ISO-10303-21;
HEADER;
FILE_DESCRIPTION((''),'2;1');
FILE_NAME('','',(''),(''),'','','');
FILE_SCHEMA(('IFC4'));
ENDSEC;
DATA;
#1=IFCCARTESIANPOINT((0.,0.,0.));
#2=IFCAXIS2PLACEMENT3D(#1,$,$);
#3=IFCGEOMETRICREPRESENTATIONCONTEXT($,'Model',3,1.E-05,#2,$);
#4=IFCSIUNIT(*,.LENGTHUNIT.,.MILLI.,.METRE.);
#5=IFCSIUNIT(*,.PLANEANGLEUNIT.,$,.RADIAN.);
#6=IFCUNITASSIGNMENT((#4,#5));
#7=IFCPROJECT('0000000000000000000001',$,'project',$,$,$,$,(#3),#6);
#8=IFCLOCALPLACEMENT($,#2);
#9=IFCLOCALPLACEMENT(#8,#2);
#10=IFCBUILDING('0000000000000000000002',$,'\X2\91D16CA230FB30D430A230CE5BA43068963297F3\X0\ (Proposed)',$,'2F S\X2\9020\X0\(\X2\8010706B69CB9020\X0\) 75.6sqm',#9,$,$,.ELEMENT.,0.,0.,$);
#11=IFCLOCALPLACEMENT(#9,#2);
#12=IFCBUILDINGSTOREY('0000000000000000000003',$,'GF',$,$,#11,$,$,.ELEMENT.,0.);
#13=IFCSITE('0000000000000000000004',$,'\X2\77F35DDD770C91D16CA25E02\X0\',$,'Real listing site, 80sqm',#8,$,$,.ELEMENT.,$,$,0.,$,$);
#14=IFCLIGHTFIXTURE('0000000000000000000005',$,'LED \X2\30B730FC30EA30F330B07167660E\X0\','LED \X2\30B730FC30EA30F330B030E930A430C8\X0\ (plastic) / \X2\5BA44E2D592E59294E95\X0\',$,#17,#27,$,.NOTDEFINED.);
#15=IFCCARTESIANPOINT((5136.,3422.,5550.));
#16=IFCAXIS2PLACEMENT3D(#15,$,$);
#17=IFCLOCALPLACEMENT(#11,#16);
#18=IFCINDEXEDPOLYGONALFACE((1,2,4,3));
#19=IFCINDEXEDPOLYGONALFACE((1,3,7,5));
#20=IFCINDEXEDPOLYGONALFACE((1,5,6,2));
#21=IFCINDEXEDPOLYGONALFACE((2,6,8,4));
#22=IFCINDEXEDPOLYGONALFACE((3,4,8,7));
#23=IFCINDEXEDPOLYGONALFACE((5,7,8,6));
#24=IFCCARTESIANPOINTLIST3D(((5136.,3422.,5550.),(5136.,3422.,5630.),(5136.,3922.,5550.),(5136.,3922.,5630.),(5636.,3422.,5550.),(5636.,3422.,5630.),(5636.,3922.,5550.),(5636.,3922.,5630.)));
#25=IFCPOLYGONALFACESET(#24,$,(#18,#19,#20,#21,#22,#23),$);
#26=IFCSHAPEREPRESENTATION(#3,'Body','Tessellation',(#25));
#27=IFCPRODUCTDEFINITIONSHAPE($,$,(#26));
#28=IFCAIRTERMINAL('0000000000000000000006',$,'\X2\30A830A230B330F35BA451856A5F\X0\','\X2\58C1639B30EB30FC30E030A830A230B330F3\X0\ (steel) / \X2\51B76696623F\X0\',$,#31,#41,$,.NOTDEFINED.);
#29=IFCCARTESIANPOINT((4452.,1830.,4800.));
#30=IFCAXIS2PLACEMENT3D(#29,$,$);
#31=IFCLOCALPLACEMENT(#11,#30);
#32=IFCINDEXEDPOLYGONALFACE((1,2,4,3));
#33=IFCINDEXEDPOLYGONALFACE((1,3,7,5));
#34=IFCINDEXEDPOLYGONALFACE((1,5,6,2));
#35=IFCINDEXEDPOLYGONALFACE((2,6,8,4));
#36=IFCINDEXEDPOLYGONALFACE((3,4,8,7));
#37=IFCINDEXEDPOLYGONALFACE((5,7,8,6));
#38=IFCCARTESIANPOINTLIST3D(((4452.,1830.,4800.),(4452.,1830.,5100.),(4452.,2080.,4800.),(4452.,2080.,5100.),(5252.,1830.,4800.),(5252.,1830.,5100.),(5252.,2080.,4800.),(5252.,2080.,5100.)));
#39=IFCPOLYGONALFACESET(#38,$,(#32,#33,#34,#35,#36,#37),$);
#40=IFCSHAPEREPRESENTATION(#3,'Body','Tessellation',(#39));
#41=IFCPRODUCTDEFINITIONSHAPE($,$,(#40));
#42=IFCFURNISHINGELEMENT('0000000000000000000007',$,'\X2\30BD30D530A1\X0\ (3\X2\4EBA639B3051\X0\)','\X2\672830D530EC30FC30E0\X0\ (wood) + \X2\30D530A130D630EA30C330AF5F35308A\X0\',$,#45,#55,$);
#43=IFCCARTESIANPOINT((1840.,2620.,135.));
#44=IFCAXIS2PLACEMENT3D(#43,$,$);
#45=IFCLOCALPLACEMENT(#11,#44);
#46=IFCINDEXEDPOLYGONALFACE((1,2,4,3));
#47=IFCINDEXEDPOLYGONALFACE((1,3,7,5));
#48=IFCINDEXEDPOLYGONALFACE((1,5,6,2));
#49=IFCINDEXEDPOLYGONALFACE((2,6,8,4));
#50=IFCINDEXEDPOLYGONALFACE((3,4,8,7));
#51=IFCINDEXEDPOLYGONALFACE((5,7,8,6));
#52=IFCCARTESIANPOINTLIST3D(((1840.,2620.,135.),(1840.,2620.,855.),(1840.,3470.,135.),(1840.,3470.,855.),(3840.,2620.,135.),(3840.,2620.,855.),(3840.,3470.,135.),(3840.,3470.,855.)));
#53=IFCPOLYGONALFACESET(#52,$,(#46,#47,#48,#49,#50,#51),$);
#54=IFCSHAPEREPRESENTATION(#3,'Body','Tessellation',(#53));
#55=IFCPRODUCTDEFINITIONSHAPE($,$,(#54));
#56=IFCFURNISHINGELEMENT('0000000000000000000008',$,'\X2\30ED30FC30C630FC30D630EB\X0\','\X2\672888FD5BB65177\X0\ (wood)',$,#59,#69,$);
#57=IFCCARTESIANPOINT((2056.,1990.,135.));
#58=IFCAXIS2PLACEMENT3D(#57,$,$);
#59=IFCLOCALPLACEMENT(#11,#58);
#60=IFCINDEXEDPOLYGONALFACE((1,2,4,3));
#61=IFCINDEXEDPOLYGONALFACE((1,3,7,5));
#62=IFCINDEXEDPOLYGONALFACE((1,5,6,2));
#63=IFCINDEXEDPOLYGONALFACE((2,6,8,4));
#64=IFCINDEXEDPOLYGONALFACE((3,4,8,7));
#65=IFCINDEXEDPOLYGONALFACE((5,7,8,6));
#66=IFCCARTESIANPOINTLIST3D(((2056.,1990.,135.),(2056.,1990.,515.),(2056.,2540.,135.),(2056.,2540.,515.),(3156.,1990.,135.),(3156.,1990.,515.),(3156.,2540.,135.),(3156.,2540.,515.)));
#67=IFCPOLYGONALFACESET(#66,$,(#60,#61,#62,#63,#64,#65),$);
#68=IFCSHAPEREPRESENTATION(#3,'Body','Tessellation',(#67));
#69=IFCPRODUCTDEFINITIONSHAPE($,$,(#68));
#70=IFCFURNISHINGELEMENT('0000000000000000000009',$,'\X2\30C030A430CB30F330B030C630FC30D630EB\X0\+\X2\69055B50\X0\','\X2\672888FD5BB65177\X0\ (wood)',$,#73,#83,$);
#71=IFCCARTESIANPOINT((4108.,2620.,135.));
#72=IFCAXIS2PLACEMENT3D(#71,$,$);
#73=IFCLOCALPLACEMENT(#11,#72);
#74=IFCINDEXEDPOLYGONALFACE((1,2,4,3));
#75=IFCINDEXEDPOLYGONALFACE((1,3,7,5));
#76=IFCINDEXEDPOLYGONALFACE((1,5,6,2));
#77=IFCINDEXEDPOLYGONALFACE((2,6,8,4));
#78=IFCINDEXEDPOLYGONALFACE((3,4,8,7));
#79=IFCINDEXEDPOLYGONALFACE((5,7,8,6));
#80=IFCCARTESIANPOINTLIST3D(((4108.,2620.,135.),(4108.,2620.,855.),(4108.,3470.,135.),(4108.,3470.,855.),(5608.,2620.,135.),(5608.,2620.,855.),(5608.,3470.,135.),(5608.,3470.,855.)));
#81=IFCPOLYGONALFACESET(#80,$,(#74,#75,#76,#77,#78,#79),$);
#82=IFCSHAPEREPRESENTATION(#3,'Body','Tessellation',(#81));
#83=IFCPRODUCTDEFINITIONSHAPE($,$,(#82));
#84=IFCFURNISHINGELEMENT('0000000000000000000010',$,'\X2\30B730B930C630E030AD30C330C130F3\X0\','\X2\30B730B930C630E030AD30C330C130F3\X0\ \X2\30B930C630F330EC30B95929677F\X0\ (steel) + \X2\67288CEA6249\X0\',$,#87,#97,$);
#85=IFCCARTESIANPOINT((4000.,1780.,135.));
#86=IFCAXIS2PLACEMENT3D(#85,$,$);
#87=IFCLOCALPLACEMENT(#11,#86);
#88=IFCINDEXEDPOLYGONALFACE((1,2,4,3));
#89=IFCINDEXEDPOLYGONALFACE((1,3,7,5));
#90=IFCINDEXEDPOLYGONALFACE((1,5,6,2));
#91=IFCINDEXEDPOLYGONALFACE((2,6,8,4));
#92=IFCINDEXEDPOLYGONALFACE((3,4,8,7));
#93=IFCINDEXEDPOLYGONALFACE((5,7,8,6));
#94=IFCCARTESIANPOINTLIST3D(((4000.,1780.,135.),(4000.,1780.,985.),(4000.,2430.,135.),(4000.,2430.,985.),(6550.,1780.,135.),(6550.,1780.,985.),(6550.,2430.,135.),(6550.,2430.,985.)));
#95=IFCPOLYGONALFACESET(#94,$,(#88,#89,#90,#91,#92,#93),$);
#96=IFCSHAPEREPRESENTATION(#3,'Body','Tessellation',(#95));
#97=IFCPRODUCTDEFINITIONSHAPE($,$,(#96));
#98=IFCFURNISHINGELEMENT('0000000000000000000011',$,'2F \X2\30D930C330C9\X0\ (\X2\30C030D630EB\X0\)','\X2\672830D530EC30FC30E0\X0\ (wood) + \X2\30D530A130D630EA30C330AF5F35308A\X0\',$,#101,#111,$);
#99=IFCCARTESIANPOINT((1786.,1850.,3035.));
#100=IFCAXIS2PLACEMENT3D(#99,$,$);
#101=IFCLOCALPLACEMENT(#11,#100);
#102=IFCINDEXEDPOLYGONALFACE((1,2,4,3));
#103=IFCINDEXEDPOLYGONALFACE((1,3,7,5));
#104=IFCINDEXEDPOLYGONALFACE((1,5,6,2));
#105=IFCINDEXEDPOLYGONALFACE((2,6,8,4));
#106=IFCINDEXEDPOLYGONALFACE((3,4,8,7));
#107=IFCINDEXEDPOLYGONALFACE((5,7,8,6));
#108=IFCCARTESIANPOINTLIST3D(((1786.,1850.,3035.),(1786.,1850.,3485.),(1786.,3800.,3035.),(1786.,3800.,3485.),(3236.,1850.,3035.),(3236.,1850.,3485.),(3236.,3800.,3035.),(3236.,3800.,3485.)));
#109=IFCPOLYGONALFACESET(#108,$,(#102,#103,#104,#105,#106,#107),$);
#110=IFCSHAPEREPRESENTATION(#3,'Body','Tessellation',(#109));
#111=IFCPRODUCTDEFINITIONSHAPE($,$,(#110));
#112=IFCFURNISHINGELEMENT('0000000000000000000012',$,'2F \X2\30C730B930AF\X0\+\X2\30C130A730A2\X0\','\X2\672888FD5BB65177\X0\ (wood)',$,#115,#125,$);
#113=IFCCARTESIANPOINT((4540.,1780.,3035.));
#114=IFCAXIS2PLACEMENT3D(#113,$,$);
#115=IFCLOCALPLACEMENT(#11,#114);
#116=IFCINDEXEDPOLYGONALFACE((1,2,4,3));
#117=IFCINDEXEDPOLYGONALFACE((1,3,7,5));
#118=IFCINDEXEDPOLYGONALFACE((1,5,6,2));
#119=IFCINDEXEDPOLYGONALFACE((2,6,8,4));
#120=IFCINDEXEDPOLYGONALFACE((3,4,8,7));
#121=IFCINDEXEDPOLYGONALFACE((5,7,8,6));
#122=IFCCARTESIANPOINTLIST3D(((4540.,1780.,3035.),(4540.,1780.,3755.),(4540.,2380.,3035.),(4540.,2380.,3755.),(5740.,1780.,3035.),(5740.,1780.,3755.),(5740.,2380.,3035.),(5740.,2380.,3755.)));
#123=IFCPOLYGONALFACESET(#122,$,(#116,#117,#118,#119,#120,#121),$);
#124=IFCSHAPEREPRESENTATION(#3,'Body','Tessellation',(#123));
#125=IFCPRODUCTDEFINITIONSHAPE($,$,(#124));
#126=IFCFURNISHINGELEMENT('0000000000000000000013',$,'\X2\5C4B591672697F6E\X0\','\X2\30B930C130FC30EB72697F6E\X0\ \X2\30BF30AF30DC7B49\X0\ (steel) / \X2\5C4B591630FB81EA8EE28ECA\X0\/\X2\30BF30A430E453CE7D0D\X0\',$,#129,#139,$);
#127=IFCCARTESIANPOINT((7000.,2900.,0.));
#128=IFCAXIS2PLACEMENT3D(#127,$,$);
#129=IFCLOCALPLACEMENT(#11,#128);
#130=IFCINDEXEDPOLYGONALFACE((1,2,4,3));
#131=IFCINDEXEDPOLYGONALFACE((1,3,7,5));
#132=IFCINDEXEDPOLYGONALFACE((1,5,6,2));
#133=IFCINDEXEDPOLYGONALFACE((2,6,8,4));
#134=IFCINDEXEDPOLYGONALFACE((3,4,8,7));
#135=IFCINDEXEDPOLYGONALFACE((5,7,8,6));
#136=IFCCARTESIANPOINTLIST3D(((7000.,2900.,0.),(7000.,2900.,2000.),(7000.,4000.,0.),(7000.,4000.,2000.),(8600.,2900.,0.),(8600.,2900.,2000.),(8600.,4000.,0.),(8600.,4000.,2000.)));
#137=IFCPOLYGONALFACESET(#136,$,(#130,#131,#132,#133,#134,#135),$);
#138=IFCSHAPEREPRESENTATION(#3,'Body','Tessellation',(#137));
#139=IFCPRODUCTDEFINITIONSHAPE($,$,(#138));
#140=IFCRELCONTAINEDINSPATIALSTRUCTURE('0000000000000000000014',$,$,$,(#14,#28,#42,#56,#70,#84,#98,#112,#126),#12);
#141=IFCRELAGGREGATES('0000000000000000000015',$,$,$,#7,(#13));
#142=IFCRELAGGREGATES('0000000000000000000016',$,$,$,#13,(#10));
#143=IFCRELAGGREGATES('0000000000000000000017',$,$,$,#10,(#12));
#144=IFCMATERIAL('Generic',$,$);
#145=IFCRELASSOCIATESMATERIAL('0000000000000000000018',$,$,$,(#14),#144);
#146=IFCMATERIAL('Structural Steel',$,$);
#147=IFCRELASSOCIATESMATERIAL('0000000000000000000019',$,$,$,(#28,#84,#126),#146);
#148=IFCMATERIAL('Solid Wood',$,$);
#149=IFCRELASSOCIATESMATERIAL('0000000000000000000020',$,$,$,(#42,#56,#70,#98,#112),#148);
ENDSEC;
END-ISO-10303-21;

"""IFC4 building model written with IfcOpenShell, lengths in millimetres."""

from ifc_helpers import new_model, si_unit, frame, frame_2d, origin, place, context, project, spatial, rectangle, extrude, material, element, save


model = new_model("IFC4")

# Units and contexts
model_context = context("Model", 3, precision=1e-05, world=origin())
ifc_project = project(units=[si_unit("LENGTHUNIT", "METRE", prefix="MILLI"), si_unit("PLANEANGLEUNIT", "RADIAN")], contexts=[model_context])

# Site, building, storey
site_placement = place(None, origin())
site = spatial("IfcSite", under=ifc_project, at=site_placement, Name="石川県金沢市", ObjectType="Real listing site, 80sqm", CompositionType="ELEMENT", RefElevation=0.0)
building_placement = place(site_placement, origin())
building = spatial("IfcBuilding", under=site, at=building_placement, Name="金沢・ピアノ室と防音 (Proposed)", ObjectType="2F S造(耐火構造) 75.6sqm", CompositionType="ELEMENT", ElevationOfRefHeight=0.0, ElevationOfTerrain=0.0)
storey_placement = place(building_placement, origin())
storey = spatial("IfcBuildingStorey", under=building, at=storey_placement, Name="GF", CompositionType="ELEMENT", Elevation=0.0)

# Shared definitions
ifc_material_1 = material(Name="Solid Wood")

# Shared definitions
ifc_material_2 = material(Name="Generic")

# Shared definitions
ifc_material_3 = material(Name="Structural Steel")

# Light fixture
light_fixture_placement = place(storey_placement, frame((5136.0, 3422.0, 5550.0)))
element("IfcLightFixture", 1, at=light_fixture_placement, inside=storey, material=ifc_material_2, Name="LED シーリング照明", Description="LED シーリングライト (plastic) / 室中央天井", PredefinedType="NOTDEFINED", context=model_context, shape_type="SweptSolid", body=[
    extrude(rectangle(XDim=500.0, YDim=500.0, at=frame_2d((250.0, 250.0))), frame((5136.0, 3422.0, 5550.0)), (0.0, 0.0, 1.0), 80.0),
])

# Air terminal
air_terminal_1_placement = place(storey_placement, frame((4452.0, 1830.0, 4800.0)))
element("IfcAirTerminal", 2, at=air_terminal_1_placement, inside=storey, material=ifc_material_3, Name="エアコン室内機", Description="壁掛ルームエアコン (steel) / 冷暖房", PredefinedType="NOTDEFINED", context=model_context, shape_type="SweptSolid", body=[
    extrude(rectangle(XDim=800.0, YDim=250.0, at=frame_2d((400.0, 125.0))), frame((4452.0, 1830.0, 4800.0)), (0.0, 0.0, 1.0), 300.0),
])

# Furnishing elements
furnishing_1_placement = place(storey_placement, frame((1840.0, 2620.0, 135.0)))
element("IfcFurnishingElement", 3, at=furnishing_1_placement, inside=storey, material=ifc_material_1, Name="ソファ (3人掛け)", Description="木フレーム (wood) + ファブリック張り", context=model_context, shape_type="SweptSolid", body=[
    extrude(rectangle(XDim=2000.0, YDim=850.0, at=frame_2d((1000.0, 425.0))), frame((1840.0, 2620.0, 135.0)), (0.0, 0.0, 1.0), 720.0),
])
furnishing_2_placement = place(storey_placement, frame((2056.0, 1990.0, 135.0)))
element("IfcFurnishingElement", 4, at=furnishing_2_placement, inside=storey, material=ifc_material_1, Name="ローテーブル", Description="木製家具 (wood)", context=model_context, shape_type="SweptSolid", body=[
    extrude(rectangle(XDim=1100.0, YDim=550.0, at=frame_2d((550.0, 275.0))), frame((2056.0, 1990.0, 135.0)), (0.0, 0.0, 1.0), 380.0),
])
furnishing_3_placement = place(storey_placement, frame((4108.0, 2620.0, 135.0)))
element("IfcFurnishingElement", 5, at=furnishing_3_placement, inside=storey, material=ifc_material_1, Name="ダイニングテーブル+椅子", Description="木製家具 (wood)", context=model_context, shape_type="SweptSolid", body=[
    extrude(rectangle(XDim=1500.0, YDim=850.0, at=frame_2d((750.0, 425.0))), frame((4108.0, 2620.0, 135.0)), (0.0, 0.0, 1.0), 720.0),
])
furnishing_4_placement = place(storey_placement, frame((4000.0, 1780.0, 135.0)))
element("IfcFurnishingElement", 6, at=furnishing_4_placement, inside=storey, material=ifc_material_3, Name="システムキッチン", Description="システムキッチン ステンレス天板 (steel) + 木質扉", context=model_context, shape_type="SweptSolid", body=[
    extrude(rectangle(XDim=2550.0, YDim=650.0, at=frame_2d((1275.0, 325.0))), frame((4000.0, 1780.0, 135.0)), (0.0, 0.0, 1.0), 850.0),
])
furnishing_5_placement = place(storey_placement, frame((1786.0, 1850.0, 3035.0)))
element("IfcFurnishingElement", 7, at=furnishing_5_placement, inside=storey, material=ifc_material_1, Name="2F ベッド (ダブル)", Description="木フレーム (wood) + ファブリック張り", context=model_context, shape_type="SweptSolid", body=[
    extrude(rectangle(XDim=1450.0, YDim=1950.0, at=frame_2d((725.0, 975.0))), frame((1786.0, 1850.0, 3035.0)), (0.0, 0.0, 1.0), 450.0),
])
furnishing_6_placement = place(storey_placement, frame((4540.0, 1780.0, 3035.0)))
element("IfcFurnishingElement", 8, at=furnishing_6_placement, inside=storey, material=ifc_material_1, Name="2F デスク+チェア", Description="木製家具 (wood)", context=model_context, shape_type="SweptSolid", body=[
    extrude(rectangle(XDim=1200.0, YDim=600.0, at=frame_2d((600.0, 300.0))), frame((4540.0, 1780.0, 3035.0)), (0.0, 0.0, 1.0), 720.0),
])
furnishing_7_placement = place(storey_placement, frame((7000.0, 2900.0, 0.0)))
element("IfcFurnishingElement", 9, at=furnishing_7_placement, inside=storey, material=ifc_material_3, Name="屋外物置", Description="スチール物置 タクボ等 (steel) / 屋外・自転車/タイヤ収納", context=model_context, shape_type="SweptSolid", body=[
    extrude(rectangle(XDim=1600.0, YDim=1100.0, at=frame_2d((800.0, 550.0))), frame((7000.0, 2900.0, 0.0)), (0.0, 0.0, 1.0), 2000.0),
])

save(model, "model.ifc")
